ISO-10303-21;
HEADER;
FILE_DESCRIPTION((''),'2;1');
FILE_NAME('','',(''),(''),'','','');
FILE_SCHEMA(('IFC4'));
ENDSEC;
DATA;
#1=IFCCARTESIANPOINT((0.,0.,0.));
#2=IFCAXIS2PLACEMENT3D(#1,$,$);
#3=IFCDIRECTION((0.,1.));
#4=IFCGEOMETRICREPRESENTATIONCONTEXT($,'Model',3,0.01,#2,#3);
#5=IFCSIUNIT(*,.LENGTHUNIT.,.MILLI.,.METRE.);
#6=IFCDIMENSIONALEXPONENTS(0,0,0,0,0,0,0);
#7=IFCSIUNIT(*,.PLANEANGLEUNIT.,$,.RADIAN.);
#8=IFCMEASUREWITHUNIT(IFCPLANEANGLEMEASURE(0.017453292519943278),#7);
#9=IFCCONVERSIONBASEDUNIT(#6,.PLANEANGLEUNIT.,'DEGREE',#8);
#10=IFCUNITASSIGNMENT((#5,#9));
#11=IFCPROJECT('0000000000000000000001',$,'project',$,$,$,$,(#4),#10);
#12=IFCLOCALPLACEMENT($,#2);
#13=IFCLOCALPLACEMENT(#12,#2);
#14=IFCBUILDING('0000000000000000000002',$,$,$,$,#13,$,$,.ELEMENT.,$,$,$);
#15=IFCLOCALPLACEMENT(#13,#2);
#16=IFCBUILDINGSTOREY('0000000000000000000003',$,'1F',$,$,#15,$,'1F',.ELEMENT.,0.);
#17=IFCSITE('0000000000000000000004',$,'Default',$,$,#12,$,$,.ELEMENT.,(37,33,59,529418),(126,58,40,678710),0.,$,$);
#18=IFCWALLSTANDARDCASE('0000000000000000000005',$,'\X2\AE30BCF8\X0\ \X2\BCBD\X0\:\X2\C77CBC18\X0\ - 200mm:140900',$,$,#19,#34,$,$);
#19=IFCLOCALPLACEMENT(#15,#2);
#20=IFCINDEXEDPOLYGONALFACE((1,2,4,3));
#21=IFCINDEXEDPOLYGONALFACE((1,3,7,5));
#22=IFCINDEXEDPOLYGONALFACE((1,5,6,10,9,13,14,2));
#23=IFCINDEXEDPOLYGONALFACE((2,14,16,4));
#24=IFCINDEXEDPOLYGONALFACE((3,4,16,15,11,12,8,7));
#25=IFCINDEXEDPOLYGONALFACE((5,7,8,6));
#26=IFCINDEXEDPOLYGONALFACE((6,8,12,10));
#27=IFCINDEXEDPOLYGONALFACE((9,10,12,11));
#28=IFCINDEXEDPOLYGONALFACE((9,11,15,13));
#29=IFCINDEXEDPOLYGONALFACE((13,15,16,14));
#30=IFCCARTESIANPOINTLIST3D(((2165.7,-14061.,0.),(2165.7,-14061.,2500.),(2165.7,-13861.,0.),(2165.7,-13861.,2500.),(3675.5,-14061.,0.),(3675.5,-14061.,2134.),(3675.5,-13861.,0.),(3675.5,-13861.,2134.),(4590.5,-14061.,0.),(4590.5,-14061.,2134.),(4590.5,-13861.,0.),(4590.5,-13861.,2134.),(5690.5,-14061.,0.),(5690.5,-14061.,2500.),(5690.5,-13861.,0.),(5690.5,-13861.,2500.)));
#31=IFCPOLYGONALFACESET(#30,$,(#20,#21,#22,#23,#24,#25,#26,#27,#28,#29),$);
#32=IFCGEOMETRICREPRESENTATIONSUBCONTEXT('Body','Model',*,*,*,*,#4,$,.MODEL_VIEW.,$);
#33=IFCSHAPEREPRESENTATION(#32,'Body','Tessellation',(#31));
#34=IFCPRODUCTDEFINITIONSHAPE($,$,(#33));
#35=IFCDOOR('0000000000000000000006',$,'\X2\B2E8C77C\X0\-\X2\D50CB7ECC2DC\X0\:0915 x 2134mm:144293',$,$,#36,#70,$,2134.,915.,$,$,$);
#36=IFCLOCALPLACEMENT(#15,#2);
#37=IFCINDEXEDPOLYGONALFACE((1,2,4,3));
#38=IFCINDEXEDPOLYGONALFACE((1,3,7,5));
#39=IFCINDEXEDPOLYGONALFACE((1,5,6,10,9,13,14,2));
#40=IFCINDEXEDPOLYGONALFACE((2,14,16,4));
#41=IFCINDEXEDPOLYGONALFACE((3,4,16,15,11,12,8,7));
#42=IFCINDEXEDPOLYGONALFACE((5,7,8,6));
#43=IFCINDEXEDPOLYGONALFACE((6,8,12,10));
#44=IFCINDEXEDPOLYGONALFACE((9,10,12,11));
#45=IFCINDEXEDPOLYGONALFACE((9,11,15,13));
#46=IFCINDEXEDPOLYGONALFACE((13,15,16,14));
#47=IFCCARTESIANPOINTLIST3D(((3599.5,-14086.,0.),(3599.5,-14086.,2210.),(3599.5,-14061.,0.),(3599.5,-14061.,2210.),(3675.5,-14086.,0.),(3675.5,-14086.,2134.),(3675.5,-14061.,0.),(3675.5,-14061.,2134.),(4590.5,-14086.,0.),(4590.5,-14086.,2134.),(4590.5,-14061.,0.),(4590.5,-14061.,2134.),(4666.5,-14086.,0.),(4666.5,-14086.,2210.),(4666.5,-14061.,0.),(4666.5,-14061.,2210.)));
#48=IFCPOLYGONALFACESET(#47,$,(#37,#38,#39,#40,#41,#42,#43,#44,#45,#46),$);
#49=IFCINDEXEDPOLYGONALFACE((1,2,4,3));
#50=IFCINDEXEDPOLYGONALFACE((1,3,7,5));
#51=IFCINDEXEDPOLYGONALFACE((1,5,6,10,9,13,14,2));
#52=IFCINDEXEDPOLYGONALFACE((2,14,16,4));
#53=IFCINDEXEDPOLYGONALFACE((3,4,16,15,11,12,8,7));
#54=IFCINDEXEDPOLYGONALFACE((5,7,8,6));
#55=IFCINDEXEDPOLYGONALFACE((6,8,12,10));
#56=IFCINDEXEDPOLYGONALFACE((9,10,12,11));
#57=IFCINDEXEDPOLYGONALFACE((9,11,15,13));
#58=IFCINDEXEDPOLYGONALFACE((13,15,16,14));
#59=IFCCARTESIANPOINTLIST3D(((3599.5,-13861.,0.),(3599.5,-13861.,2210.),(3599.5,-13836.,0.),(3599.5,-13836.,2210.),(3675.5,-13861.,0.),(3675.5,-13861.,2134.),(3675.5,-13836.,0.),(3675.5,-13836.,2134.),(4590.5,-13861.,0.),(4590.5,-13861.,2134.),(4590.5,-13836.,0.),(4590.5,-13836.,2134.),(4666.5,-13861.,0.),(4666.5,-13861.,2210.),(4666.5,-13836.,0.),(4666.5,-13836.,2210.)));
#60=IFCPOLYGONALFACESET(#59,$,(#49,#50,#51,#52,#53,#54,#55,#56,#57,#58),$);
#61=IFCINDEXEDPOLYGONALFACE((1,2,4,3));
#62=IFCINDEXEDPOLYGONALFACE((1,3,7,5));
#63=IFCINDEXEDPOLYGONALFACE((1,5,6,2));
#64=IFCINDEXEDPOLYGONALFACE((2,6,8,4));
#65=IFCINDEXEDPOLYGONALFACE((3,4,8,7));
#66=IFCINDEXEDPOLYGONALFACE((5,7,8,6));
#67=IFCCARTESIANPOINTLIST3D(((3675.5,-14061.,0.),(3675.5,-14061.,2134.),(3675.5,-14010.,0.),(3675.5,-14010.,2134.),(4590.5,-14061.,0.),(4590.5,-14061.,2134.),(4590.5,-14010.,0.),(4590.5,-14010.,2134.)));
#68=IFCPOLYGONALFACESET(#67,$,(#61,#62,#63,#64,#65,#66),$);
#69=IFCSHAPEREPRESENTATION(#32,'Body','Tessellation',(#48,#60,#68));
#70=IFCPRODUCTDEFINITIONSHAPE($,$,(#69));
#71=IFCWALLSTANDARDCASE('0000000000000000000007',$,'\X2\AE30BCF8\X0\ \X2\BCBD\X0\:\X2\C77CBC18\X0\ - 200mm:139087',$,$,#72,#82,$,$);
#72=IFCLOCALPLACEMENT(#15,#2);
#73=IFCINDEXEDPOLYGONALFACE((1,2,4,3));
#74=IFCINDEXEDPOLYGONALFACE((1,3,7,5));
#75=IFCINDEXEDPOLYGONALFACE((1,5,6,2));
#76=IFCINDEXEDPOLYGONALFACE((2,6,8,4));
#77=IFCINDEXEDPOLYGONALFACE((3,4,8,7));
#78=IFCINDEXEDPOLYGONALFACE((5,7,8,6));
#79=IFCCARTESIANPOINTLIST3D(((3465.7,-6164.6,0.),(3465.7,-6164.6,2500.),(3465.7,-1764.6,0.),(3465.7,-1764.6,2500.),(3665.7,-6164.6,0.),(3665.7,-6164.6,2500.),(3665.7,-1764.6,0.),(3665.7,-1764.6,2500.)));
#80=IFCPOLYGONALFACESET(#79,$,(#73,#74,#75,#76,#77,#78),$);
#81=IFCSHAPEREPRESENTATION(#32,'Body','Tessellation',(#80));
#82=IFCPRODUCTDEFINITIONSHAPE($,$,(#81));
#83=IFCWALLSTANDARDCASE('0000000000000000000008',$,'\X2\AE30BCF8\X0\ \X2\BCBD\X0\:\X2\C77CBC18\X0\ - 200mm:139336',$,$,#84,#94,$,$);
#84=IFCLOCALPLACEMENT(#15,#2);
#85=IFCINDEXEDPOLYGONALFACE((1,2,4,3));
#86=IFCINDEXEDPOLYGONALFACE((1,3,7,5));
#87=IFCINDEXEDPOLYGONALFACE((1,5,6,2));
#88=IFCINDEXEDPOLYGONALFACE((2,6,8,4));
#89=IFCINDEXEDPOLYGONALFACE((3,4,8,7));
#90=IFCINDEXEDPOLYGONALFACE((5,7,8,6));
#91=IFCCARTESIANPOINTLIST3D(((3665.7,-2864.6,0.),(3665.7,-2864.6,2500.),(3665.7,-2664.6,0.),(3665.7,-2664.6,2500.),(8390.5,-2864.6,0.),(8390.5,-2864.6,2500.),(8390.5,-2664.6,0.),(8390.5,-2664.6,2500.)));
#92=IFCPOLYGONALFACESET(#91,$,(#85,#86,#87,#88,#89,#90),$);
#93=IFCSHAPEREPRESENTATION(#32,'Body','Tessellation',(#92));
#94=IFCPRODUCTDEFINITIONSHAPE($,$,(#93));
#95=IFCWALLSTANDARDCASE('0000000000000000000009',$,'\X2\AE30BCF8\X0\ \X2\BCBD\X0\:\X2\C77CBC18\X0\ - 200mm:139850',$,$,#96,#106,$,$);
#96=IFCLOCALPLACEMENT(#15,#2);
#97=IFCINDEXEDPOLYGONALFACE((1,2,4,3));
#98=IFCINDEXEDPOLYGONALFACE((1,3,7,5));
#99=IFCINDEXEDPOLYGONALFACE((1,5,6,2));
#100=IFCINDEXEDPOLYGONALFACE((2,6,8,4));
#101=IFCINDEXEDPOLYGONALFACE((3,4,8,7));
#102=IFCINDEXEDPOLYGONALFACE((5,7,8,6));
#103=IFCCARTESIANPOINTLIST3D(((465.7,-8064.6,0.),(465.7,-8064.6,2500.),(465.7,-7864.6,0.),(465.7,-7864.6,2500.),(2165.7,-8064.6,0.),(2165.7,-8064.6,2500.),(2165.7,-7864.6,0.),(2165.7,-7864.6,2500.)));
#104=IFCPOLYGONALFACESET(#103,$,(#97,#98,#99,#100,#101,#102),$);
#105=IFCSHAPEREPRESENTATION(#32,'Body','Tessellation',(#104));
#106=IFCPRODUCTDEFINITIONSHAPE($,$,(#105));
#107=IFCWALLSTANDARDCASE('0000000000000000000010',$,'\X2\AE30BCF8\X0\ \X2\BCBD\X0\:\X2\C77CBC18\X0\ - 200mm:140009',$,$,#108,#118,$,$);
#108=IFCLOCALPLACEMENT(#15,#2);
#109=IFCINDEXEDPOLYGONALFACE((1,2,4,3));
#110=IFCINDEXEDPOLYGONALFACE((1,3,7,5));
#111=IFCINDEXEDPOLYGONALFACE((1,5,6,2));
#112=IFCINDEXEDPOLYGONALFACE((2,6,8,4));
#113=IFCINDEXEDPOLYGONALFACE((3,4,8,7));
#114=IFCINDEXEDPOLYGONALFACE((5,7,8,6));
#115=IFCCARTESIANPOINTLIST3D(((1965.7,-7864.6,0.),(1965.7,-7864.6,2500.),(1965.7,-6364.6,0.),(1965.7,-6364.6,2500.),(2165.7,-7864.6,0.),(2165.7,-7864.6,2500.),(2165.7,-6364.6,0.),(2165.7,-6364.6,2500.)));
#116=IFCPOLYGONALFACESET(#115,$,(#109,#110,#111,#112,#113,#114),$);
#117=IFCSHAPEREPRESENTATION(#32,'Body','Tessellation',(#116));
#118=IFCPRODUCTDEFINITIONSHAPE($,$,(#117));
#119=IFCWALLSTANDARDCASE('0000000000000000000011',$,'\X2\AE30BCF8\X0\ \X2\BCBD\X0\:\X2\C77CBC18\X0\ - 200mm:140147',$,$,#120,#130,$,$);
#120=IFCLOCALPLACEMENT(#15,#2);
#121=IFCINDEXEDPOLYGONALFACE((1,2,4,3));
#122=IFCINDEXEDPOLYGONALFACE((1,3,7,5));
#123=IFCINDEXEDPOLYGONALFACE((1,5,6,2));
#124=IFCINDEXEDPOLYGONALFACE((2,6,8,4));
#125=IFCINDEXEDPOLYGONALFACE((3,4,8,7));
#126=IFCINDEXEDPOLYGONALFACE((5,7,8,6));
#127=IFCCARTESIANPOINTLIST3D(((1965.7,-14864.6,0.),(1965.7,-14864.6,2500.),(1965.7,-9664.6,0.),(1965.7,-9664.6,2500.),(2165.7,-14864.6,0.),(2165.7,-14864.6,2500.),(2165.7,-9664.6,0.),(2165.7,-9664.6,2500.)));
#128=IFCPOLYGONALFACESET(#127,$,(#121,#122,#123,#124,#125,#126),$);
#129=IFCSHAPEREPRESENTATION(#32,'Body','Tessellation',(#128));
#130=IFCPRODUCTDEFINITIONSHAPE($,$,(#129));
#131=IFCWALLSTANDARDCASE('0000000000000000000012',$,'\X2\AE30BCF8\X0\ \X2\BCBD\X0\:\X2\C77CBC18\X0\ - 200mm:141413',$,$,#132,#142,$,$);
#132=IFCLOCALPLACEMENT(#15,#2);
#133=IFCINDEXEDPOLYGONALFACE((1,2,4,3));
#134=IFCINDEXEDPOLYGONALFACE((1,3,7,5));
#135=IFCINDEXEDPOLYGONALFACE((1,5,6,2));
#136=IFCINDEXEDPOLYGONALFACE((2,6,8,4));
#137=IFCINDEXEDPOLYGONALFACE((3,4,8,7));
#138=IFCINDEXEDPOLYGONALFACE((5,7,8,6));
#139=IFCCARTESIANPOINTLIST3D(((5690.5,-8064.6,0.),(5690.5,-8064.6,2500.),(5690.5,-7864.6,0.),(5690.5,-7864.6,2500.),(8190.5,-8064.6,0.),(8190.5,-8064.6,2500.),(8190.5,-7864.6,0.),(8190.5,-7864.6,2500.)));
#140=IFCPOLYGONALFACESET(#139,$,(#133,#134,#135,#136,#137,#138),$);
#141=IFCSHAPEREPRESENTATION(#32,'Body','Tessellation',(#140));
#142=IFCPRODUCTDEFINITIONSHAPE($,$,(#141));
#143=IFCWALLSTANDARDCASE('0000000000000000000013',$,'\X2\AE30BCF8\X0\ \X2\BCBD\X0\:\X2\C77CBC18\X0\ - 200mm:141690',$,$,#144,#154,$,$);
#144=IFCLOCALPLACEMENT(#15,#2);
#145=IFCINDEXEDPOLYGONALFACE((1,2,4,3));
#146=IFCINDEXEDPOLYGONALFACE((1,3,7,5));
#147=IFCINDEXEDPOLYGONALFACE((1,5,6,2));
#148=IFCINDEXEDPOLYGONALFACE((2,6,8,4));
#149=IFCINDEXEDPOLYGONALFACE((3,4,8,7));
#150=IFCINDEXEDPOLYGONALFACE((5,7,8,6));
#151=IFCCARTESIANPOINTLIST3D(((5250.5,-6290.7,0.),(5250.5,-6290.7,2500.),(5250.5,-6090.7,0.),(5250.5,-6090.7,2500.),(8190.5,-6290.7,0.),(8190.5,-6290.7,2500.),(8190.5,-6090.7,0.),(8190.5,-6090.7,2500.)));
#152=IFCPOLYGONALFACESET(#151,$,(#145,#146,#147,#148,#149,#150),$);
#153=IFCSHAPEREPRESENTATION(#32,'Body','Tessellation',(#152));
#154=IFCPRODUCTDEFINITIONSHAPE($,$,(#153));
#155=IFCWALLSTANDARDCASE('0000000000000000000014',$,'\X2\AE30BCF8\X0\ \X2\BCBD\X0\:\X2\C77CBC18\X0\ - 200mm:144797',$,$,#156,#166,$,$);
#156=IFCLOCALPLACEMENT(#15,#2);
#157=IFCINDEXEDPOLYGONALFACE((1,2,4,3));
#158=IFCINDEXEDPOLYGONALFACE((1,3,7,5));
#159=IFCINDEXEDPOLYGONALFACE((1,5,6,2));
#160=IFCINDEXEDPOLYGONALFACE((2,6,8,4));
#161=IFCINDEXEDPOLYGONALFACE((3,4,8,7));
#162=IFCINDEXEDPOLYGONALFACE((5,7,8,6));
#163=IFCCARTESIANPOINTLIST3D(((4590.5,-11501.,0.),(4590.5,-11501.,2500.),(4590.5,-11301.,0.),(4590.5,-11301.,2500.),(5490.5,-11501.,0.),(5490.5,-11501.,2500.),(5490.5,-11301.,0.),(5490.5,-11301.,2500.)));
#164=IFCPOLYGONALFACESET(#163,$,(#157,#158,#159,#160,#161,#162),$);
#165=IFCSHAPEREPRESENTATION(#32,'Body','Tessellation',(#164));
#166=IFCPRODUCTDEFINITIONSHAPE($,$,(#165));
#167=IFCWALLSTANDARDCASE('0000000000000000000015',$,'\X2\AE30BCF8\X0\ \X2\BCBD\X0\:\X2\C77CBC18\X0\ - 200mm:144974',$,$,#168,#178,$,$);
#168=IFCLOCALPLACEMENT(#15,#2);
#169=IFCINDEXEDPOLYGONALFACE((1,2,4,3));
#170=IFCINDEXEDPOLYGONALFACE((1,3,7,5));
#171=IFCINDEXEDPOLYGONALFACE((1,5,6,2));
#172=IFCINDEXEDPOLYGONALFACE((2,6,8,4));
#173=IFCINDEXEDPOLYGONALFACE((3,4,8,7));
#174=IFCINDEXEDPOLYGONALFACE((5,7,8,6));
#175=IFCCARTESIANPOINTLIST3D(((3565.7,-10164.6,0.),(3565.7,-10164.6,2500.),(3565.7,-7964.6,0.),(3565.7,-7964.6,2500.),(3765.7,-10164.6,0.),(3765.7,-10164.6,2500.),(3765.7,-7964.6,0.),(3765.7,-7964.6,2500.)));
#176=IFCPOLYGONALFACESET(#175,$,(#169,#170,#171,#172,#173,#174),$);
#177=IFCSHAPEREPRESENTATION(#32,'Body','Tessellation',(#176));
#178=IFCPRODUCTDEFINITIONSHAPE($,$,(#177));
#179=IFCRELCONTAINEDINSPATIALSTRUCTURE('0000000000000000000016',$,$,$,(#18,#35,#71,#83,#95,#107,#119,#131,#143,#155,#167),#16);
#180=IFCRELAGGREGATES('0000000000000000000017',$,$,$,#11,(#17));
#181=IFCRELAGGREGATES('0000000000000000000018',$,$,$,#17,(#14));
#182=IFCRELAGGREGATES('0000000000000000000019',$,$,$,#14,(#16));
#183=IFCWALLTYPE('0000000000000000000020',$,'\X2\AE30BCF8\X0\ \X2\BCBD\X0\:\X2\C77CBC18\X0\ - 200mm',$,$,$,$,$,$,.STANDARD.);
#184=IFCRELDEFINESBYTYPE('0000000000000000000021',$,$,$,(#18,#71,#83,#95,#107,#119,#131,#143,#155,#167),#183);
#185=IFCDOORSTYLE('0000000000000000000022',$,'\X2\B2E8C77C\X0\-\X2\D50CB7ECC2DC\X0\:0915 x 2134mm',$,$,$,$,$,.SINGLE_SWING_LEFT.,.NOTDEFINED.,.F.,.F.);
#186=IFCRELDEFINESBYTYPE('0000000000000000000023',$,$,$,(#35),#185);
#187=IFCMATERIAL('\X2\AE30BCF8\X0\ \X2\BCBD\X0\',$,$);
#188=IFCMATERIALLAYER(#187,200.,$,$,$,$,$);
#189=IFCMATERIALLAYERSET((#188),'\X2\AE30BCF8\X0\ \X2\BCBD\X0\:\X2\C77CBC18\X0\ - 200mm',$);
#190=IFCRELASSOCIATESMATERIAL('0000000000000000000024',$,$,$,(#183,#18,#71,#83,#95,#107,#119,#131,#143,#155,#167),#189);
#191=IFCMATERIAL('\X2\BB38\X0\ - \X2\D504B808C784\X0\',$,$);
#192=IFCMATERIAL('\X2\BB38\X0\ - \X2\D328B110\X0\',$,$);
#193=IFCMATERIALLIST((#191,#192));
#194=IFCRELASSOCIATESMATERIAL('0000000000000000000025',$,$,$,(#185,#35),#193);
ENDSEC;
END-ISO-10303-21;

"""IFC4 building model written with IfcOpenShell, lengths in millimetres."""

from ifc_helpers import new_model, entity, si_unit, converted_unit, direction, frame, frame_2d, origin, place, context, subcontext, project, spatial, polyline, rectangle, outline, extrude, source, transform, mapped, material, material_list, layer, layer_set, layer_usage, type_object, type_shapes, element, fill, save


model = new_model("IFC4")

# Units and contexts
model_context = context("Model", 3, precision=0.01, world=origin(), true_north=direction((0.0, 1.0)))
body_context = subcontext(model_context, "Body", "Model", "MODEL_VIEW")
ifc_project = project(units=[si_unit("LENGTHUNIT", "METRE", prefix="MILLI"), converted_unit("PLANEANGLEUNIT", "DEGREE", entity("IfcPlaneAngleMeasure", 0.017453292519943278), si_unit("PLANEANGLEUNIT", "RADIAN"), dimensions=[0, 0, 0, 0, 0, 0, 0])], contexts=[model_context])

# Site, building, storey
site_placement = place(None, origin())
site = spatial("IfcSite", under=ifc_project, at=site_placement, Name="Default", CompositionType="ELEMENT", RefLatitude=(37, 33, 59, 529418), RefLongitude=(126, 58, 40, 678710), RefElevation=0.0)
building_placement = place(site_placement, origin())
building = spatial("IfcBuilding", under=site, at=building_placement, CompositionType="ELEMENT")
storey_placement = place(building_placement, origin())
storey = spatial("IfcBuildingStorey", under=building, at=storey_placement, Name="1F", LongName="1F", CompositionType="ELEMENT", Elevation=0.0)

# Shared definitions
ifc_material_1 = material(Name="기본 벽")
ifc_layer = layer(ifc_material_1, 200.0)
ifc_layer_set = layer_set([ifc_layer], Name="기본 벽:일반 - 200mm")
wall_type = type_object("IfcWallType", Name="기본 벽:일반 - 200mm", PredefinedType="STANDARD", material=ifc_layer_set)

# Shared definitions
ifc_material_2 = material(Name="문 - 프레임")
ifc_material_3 = material(Name="문 - 패널")
ifc_material_list_1 = material_list([ifc_material_2, ifc_material_3])

# Wall, opening, door
ifc_layer_usage_1 = layer_usage(ifc_layer_set, "AXIS2", "NEGATIVE", 100.0)
wall_1_placement = place(storey_placement, frame((2165.7, -13961.0, 0.0)))
wall_1 = element("IfcWallStandardCase", 1, at=wall_1_placement, inside=storey, type_object=wall_type, material=ifc_layer_usage_1, Name="기본 벽:일반 - 200mm:140900", context=body_context, shape_type="SweptSolid", body=[
    extrude(rectangle(XDim=3524.8, YDim=200.0, at=frame_2d((1762.4, 0.0), x_axis=(1.0, 0.0))), origin(), (0.0, 0.0, 1.0), 2500.0),
])
opening_1_placement = place(wall_1_placement, frame((2424.8, 100.0, 0.0)))
opening_1 = element("IfcOpeningElement", 2, at=opening_1_placement, cuts=wall_1, ObjectType="Opening", context=body_context, shape_type="SweptSolid", body=[
    extrude(rectangle(XDim=915.0, YDim=2134.0, at=frame_2d((1067.0, 457.5), x_axis=(0.0, -1.0))), frame((0.0, 0.0, 0.0), z_axis=(0.0, -1.0, 0.0), x_axis=(0.0, 0.0, 1.0)), (0.0, 0.0, 1.0), 200.0),
])
door_style_1 = type_object("IfcDoorStyle", Name="단일-플러시:0915 x 2134mm", ConstructionType="NOTDEFINED", OperationType="SINGLE_SWING_LEFT", ParameterTakesPrecedence=False, Sizeable=False, material=ifc_material_list_1)
shared_shape_1 = source(origin(), body_context, "Body", "SweptSolid", [
    extrude(outline(polyline([(-533.5, -1124.0), (533.5, -1124.0), (533.5, 1086.0), (457.5, 1086.0), (457.5, -1048.0), (-457.5, -1048.0), (-457.5, 1086.0), (-533.5, 1086.0), (-533.5, -1124.0)])), frame((457.5, 225.0, 1086.0), z_axis=(0.0, -1.0, 0.0), x_axis=(-1.0, 0.0, 0.0)), (0.0, 0.0, 1.0), 25.0),
    extrude(outline(polyline([(-1124.0, -533.5), (1086.0, -533.5), (1086.0, -457.5), (-1048.0, -457.5), (-1048.0, 457.5), (1086.0, 457.5), (1086.0, 533.5), (-1124.0, 533.5), (-1124.0, -533.5)])), frame((457.5, 0.0, 1086.0), z_axis=(0.0, -1.0, 0.0), x_axis=(0.0, 0.0, -1.0)), (0.0, 0.0, 1.0), 25.0),
    extrude(rectangle(XDim=915.0, YDim=51.0, at=frame_2d((0.0, 0.0), x_axis=(1.0, 0.0))), frame((457.5, 174.5, 0.0)), (0.0, 0.0, 1.0), 2134.0),
])
type_shapes(door_style_1, [shared_shape_1])
door_1_placement = place(opening_1_placement, frame((0.0, 0.0, 0.0), z_axis=(0.0, 0.0, 1.0), x_axis=(-1.0, 0.0, 0.0)))
door_1 = element("IfcDoor", 3, at=door_1_placement, inside=storey, type_object=door_style_1, material=ifc_material_list_1, Name="단일-플러시:0915 x 2134mm:144293", OverallHeight=2134.0, OverallWidth=915.0, context=body_context, shape_type="MappedRepresentation", body=[
    mapped(shared_shape_1, transform((0.0, 0.0, 0.0), scale=1.0)),
])
fill(opening_1, door_1)

# Walls
ifc_layer_usage_2 = layer_usage(ifc_layer_set, "AXIS2", "NEGATIVE", 100.0)
wall_2_placement = place(storey_placement, frame((3565.7, -1764.6, 0.0), z_axis=(0.0, 0.0, 1.0), x_axis=(0.0, -1.0, 0.0)))
element("IfcWallStandardCase", 4, at=wall_2_placement, inside=storey, type_object=wall_type, material=ifc_layer_usage_2, Name="기본 벽:일반 - 200mm:139087", context=body_context, shape_type="SweptSolid", body=[
    extrude(rectangle(XDim=4400.0, YDim=200.0, at=frame_2d((2200.0, 0.0), x_axis=(-1.0, 0.0))), origin(), (0.0, 0.0, 1.0), 2500.0),
])
ifc_layer_usage_3 = layer_usage(ifc_layer_set, "AXIS2", "NEGATIVE", 100.0)
wall_3_placement = place(storey_placement, frame((3665.7, -2764.6, 0.0)))
element("IfcWallStandardCase", 5, at=wall_3_placement, inside=storey, type_object=wall_type, material=ifc_layer_usage_3, Name="기본 벽:일반 - 200mm:139336", context=body_context, shape_type="SweptSolid", body=[
    extrude(rectangle(XDim=4724.8, YDim=200.0, at=frame_2d((2362.4, 0.0), x_axis=(-1.0, 0.0))), origin(), (0.0, 0.0, 1.0), 2500.0),
])
ifc_layer_usage_4 = layer_usage(ifc_layer_set, "AXIS2", "NEGATIVE", 100.0)
wall_4_placement = place(storey_placement, frame((465.7, -7964.6, 0.0)))
element("IfcWallStandardCase", 6, at=wall_4_placement, inside=storey, type_object=wall_type, material=ifc_layer_usage_4, Name="기본 벽:일반 - 200mm:139850", context=body_context, shape_type="SweptSolid", body=[
    extrude(rectangle(XDim=1700.0, YDim=200.0, at=frame_2d((850.0, 0.0), x_axis=(-1.0, 0.0))), origin(), (0.0, 0.0, 1.0), 2500.0),
])
ifc_layer_usage_5 = layer_usage(ifc_layer_set, "AXIS2", "NEGATIVE", 100.0)
wall_5_placement = place(storey_placement, frame((2065.7, -6364.6, 0.0), z_axis=(0.0, 0.0, 1.0), x_axis=(0.0, -1.0, 0.0)))
element("IfcWallStandardCase", 7, at=wall_5_placement, inside=storey, type_object=wall_type, material=ifc_layer_usage_5, Name="기본 벽:일반 - 200mm:140009", context=body_context, shape_type="SweptSolid", body=[
    extrude(rectangle(XDim=1500.0, YDim=200.0, at=frame_2d((750.0, 0.0), x_axis=(-1.0, 0.0))), origin(), (0.0, 0.0, 1.0), 2500.0),
])
ifc_layer_usage_6 = layer_usage(ifc_layer_set, "AXIS2", "NEGATIVE", 100.0)
wall_6_placement = place(storey_placement, frame((2065.7, -9664.6, 0.0), z_axis=(0.0, 0.0, 1.0), x_axis=(0.0, -1.0, 0.0)))
element("IfcWallStandardCase", 8, at=wall_6_placement, inside=storey, type_object=wall_type, material=ifc_layer_usage_6, Name="기본 벽:일반 - 200mm:140147", context=body_context, shape_type="SweptSolid", body=[
    extrude(rectangle(XDim=5200.0, YDim=200.0, at=frame_2d((2600.0, 0.0), x_axis=(-1.0, 0.0))), origin(), (0.0, 0.0, 1.0), 2500.0),
])
ifc_layer_usage_7 = layer_usage(ifc_layer_set, "AXIS2", "NEGATIVE", 100.0)
wall_7_placement = place(storey_placement, frame((8190.5, -7964.6, 0.0), z_axis=(0.0, 0.0, 1.0), x_axis=(-1.0, 0.0, 0.0)))
element("IfcWallStandardCase", 9, at=wall_7_placement, inside=storey, type_object=wall_type, material=ifc_layer_usage_7, Name="기본 벽:일반 - 200mm:141413", context=body_context, shape_type="SweptSolid", body=[
    extrude(rectangle(XDim=2500.0, YDim=200.0, at=frame_2d((1250.0, 0.0), x_axis=(-1.0, 0.0))), origin(), (0.0, 0.0, 1.0), 2500.0),
])
ifc_layer_usage_8 = layer_usage(ifc_layer_set, "AXIS2", "NEGATIVE", 100.0)
wall_8_placement = place(storey_placement, frame((5250.5, -6190.7, 0.0)))
element("IfcWallStandardCase", 10, at=wall_8_placement, inside=storey, type_object=wall_type, material=ifc_layer_usage_8, Name="기본 벽:일반 - 200mm:141690", context=body_context, shape_type="SweptSolid", body=[
    extrude(rectangle(XDim=2940.0, YDim=200.0, at=frame_2d((1470.0, 0.0), x_axis=(-1.0, 0.0))), origin(), (0.0, 0.0, 1.0), 2500.0),
])
ifc_layer_usage_9 = layer_usage(ifc_layer_set, "AXIS2", "NEGATIVE", 100.0)
wall_9_placement = place(storey_placement, frame((5490.5, -11401.0, 0.0), z_axis=(0.0, 0.0, 1.0), x_axis=(-1.0, 0.0, 0.0)))
element("IfcWallStandardCase", 11, at=wall_9_placement, inside=storey, type_object=wall_type, material=ifc_layer_usage_9, Name="기본 벽:일반 - 200mm:144797", context=body_context, shape_type="SweptSolid", body=[
    extrude(rectangle(XDim=900.0, YDim=200.0, at=frame_2d((450.0, 0.0), x_axis=(-1.0, 0.0))), origin(), (0.0, 0.0, 1.0), 2500.0),
])
ifc_layer_usage_10 = layer_usage(ifc_layer_set, "AXIS2", "NEGATIVE", 100.0)
wall_10_placement = place(storey_placement, frame((3665.7, -7964.6, 0.0), z_axis=(0.0, 0.0, 1.0), x_axis=(0.0, -1.0, 0.0)))
element("IfcWallStandardCase", 12, at=wall_10_placement, inside=storey, type_object=wall_type, material=ifc_layer_usage_10, Name="기본 벽:일반 - 200mm:144974", context=body_context, shape_type="SweptSolid", body=[
    extrude(rectangle(XDim=2200.0, YDim=200.0, at=frame_2d((1100.0, 0.0), x_axis=(-1.0, 0.0))), origin(), (0.0, 0.0, 1.0), 2500.0),
])

save(model, "model.ifc")
